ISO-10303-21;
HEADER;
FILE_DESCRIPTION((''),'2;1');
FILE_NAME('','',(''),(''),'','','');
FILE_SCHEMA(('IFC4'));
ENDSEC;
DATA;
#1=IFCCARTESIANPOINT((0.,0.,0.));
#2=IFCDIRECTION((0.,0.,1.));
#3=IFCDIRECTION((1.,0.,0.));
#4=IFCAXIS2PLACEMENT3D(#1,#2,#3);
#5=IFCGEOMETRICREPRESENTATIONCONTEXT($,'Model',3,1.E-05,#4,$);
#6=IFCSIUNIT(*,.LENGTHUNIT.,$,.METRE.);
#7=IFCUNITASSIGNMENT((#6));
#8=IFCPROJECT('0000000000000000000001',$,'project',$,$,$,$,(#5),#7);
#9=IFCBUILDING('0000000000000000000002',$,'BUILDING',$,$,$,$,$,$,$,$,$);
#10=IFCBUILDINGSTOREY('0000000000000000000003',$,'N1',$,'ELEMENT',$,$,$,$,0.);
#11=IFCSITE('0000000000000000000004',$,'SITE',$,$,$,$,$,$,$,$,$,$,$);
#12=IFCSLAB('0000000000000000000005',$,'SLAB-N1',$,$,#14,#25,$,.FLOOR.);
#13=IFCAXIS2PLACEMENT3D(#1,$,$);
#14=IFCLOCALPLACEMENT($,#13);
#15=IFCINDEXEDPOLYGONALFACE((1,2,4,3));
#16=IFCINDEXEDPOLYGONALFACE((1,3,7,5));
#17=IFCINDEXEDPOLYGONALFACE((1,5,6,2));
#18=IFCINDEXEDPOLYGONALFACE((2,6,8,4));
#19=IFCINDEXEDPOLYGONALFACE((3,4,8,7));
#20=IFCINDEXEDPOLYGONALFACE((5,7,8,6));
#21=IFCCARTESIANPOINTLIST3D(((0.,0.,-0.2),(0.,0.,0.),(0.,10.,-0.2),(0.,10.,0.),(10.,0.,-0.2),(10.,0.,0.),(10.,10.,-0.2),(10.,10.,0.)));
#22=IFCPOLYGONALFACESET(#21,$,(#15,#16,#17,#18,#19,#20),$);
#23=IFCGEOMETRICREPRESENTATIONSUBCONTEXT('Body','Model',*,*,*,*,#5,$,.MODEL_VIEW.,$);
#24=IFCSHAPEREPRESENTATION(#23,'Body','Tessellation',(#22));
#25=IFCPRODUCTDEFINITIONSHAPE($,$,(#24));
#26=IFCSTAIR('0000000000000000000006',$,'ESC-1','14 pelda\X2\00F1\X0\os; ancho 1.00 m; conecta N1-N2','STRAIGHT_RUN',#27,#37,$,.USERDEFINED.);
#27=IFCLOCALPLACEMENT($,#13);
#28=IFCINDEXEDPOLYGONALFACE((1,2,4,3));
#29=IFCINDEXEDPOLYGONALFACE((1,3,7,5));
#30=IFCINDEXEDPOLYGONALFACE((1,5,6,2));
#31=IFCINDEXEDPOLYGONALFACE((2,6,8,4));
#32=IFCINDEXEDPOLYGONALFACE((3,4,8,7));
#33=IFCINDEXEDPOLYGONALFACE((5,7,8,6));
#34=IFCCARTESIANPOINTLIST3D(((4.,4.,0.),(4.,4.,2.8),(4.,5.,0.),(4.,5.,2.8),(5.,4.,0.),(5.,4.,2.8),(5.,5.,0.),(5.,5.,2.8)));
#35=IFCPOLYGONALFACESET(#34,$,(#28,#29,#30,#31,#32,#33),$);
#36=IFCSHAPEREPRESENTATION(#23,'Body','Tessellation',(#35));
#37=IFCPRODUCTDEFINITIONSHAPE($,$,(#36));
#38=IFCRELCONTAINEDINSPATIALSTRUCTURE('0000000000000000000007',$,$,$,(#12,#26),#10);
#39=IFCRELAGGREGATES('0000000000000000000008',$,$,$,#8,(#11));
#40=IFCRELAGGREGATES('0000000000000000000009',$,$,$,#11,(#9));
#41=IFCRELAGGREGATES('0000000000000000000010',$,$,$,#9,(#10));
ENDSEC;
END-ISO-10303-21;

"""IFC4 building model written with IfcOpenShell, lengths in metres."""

from ifc_helpers import new_model, si_unit, frame, origin_with_axes, place, context, subcontext, project, spatial, indexed_curve, outline, extrude, element, save


model = new_model("IFC4")

# Units and contexts
model_context = context("Model", 3, precision=1e-05, world=origin_with_axes())
body_context = subcontext(model_context, "Body", "Model", "MODEL_VIEW")
ifc_project = project(units=[si_unit("LENGTHUNIT", "METRE")], contexts=[model_context])

# Site, building, storey
site = spatial("IfcSite", under=ifc_project, Name="SITE")
building = spatial("IfcBuilding", under=site, Name="BUILDING")
storey = spatial("IfcBuildingStorey", under=building, Name="N1", ObjectType="ELEMENT", Elevation=0.0)

# Slab
slab_placement = place(None, frame((0.0, 0.0, -0.2), z_axis=(0.0, 0.0, 1.0), x_axis=(1.0, 0.0, 0.0)))
element("IfcSlab", 1, at=slab_placement, inside=storey, Name="SLAB-N1", PredefinedType="FLOOR", context=body_context, shape_type="SweptSolid", body=[
    extrude(outline(indexed_curve([(0.0, 0.0), (10.0, 0.0), (10.0, 10.0), (0.0, 10.0), (0.0, 0.0)])), None, (0.0, 0.0, 1.0), 0.2),
])

# Stair
stair_placement = place(None, frame((4.0, 4.0, 0.0), z_axis=(0.0, 0.0, 1.0), x_axis=(1.0, 0.0, 0.0)))
element("IfcStair", 2, at=stair_placement, inside=storey, Name="ESC-1", Description="14 peldaños; ancho 1.00 m; conecta N1-N2", ObjectType="STRAIGHT_RUN", PredefinedType="USERDEFINED", context=body_context, shape_type="SweptSolid", body=[
    extrude(outline(indexed_curve([(0.0, 0.0), (1.0, 0.0), (1.0, 1.0), (0.0, 1.0), (0.0, 0.0)])), None, (0.0, 0.0, 1.0), 2.8),
])

save(model, "model.ifc")
